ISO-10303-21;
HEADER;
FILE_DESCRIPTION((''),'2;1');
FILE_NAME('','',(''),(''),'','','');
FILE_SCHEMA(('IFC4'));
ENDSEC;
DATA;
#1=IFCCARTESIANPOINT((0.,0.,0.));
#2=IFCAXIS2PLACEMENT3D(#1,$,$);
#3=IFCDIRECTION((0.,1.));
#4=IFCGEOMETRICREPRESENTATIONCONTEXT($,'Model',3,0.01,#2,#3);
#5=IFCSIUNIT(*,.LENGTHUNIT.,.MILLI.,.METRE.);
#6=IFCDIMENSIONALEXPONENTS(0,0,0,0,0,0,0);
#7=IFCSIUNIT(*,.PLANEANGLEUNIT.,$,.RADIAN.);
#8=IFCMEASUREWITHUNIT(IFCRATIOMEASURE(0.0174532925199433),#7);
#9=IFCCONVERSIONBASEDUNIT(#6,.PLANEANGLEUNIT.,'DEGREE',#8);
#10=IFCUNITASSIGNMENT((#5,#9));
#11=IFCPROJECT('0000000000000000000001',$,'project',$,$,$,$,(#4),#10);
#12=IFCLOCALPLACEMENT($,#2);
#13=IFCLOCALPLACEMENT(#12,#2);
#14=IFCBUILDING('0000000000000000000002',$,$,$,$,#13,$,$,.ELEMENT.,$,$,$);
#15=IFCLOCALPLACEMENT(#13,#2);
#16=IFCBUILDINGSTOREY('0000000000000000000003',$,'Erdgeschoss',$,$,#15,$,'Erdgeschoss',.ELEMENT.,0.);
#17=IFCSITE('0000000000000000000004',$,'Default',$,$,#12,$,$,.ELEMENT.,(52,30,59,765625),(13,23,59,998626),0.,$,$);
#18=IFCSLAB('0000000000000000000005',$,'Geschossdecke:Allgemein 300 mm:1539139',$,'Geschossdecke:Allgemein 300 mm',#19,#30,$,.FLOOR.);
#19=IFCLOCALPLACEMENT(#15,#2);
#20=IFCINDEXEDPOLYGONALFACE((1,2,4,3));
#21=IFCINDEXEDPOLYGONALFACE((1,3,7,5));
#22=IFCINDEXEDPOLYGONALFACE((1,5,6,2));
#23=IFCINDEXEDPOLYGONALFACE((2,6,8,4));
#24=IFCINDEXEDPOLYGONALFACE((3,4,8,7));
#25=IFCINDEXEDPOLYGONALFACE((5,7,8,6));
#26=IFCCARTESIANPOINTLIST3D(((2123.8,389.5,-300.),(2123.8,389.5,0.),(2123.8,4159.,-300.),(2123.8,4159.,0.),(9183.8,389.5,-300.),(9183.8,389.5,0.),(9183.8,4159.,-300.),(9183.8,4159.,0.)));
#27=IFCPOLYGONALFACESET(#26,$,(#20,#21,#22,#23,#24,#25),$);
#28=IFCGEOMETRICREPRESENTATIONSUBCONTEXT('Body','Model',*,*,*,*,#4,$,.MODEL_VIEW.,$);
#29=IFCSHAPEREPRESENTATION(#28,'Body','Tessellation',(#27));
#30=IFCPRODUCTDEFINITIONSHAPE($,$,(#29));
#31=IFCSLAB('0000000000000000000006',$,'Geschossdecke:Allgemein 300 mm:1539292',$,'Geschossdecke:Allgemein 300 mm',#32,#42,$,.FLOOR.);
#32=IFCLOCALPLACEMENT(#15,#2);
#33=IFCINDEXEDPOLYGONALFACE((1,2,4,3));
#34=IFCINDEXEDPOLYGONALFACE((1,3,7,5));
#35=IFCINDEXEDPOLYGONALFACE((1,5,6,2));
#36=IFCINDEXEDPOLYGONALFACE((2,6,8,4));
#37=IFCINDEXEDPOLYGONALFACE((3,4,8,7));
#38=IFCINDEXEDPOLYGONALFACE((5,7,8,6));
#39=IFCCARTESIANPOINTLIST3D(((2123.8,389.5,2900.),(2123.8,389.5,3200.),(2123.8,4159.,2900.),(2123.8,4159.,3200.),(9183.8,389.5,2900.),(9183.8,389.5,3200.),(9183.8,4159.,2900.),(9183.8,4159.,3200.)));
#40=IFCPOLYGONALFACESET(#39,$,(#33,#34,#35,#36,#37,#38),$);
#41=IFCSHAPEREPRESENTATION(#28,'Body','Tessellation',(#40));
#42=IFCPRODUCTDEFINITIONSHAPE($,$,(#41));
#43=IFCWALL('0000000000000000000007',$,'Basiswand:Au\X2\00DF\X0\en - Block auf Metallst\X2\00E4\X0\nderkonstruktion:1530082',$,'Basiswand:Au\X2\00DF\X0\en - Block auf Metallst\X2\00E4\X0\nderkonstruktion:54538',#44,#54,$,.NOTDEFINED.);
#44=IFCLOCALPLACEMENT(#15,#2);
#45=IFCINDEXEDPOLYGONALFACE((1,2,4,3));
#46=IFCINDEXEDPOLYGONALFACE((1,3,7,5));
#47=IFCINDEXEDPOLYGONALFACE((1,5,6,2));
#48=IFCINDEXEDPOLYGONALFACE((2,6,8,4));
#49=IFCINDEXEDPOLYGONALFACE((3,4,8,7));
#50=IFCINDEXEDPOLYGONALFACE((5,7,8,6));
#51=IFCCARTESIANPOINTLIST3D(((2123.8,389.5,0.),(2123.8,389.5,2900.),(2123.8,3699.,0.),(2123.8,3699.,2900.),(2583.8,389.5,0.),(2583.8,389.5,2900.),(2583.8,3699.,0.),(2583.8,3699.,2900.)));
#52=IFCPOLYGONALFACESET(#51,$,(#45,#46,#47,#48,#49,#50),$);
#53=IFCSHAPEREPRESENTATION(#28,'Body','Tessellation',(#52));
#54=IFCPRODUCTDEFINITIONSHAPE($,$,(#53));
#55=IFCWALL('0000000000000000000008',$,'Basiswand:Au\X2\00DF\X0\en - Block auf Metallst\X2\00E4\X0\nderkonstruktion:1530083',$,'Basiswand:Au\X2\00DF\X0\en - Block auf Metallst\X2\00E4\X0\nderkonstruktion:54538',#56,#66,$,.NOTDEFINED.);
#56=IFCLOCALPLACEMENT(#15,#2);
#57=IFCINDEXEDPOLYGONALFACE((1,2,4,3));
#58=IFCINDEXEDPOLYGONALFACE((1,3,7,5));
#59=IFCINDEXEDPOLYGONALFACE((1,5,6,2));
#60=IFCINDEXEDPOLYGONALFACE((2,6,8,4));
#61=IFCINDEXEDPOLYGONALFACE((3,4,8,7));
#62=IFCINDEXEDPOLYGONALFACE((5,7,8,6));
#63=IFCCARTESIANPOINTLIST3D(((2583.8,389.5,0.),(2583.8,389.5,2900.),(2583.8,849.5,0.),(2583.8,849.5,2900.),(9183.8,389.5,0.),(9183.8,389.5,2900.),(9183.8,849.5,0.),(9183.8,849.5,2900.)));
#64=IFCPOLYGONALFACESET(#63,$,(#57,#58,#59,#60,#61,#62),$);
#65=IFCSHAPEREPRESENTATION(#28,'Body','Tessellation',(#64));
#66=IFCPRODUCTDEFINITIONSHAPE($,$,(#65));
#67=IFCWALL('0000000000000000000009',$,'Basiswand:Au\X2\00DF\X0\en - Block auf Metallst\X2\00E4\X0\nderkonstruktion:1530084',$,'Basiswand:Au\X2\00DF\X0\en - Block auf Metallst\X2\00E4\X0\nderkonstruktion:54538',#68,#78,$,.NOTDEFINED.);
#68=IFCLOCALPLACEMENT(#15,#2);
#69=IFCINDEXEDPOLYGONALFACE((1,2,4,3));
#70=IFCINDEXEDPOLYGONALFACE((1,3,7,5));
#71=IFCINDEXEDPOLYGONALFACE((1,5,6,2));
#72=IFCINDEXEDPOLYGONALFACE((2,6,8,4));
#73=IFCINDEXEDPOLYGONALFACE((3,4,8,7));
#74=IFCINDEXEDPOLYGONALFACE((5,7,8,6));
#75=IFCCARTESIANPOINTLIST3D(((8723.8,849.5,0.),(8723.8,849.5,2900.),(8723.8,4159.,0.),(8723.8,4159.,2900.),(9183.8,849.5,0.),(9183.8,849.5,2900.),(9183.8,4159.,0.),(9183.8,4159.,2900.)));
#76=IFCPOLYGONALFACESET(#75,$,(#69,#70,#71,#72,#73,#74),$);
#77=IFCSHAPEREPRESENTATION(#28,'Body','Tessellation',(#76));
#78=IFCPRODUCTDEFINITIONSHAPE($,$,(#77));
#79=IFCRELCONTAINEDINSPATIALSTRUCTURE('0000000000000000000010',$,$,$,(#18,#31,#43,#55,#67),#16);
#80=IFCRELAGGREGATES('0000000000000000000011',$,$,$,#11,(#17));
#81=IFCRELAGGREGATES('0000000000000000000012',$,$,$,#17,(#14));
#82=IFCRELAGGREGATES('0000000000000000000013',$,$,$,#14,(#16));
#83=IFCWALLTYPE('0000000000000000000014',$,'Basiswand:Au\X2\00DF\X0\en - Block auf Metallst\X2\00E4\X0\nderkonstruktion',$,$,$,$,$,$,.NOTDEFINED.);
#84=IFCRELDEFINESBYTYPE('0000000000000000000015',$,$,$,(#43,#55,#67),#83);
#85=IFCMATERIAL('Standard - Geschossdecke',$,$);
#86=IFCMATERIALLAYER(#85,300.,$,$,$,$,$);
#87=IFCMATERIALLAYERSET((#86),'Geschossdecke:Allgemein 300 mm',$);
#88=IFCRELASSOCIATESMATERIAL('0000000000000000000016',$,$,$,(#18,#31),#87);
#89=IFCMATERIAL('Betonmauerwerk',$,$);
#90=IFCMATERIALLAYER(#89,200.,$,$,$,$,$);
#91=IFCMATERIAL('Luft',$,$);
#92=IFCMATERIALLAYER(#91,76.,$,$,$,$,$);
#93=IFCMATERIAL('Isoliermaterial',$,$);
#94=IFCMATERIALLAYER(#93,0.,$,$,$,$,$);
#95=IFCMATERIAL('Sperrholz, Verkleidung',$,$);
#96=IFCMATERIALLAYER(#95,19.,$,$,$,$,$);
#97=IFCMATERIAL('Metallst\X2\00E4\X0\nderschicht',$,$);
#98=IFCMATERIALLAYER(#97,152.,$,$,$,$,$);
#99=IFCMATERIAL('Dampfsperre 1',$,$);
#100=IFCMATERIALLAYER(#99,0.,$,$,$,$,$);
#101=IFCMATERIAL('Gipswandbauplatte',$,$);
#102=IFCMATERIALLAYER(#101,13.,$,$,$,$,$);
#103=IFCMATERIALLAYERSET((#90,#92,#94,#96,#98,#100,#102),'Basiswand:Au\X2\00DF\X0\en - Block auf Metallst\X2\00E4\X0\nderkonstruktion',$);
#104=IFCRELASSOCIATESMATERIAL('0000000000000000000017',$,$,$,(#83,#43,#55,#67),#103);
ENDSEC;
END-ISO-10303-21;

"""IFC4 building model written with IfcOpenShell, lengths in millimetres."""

from ifc_helpers import new_model, entity, si_unit, converted_unit, direction, frame, frame_2d, origin, origin_2d_with_axis, place, context, subcontext, project, spatial, polyline, rectangle, extrude, clip, bounded_halfspace, material, layer, layer_set, layer_usage, type_object, element, save


model = new_model("IFC4")

# Units and contexts
model_context = context("Model", 3, precision=0.01, world=origin(), true_north=direction((0.0, 1.0)))
body_context = subcontext(model_context, "Body", "Model", "MODEL_VIEW")
ifc_project = project(units=[si_unit("LENGTHUNIT", "METRE", prefix="MILLI"), converted_unit("PLANEANGLEUNIT", "DEGREE", entity("IfcRatioMeasure", 0.0174532925199433), si_unit("PLANEANGLEUNIT", "RADIAN"), dimensions=[0, 0, 0, 0, 0, 0, 0])], contexts=[model_context])

# Site, building, storey
site_placement = place(None, origin())
site = spatial("IfcSite", under=ifc_project, at=site_placement, Name="Default", CompositionType="ELEMENT", RefLatitude=(52, 30, 59, 765625), RefLongitude=(13, 23, 59, 998626), RefElevation=0.0)
building_placement = place(site_placement, origin())
building = spatial("IfcBuilding", under=site, at=building_placement, CompositionType="ELEMENT")
storey_placement = place(building_placement, origin())
storey = spatial("IfcBuildingStorey", under=building, at=storey_placement, Name="Erdgeschoss", LongName="Erdgeschoss", CompositionType="ELEMENT", Elevation=0.0)

# Slabs
ifc_material_1 = material(Name="Standard - Geschossdecke")
ifc_layer_1 = layer(ifc_material_1, 300.0)
ifc_layer_set_1 = layer_set([ifc_layer_1], Name="Geschossdecke:Allgemein 300 mm")
ifc_layer_usage_1 = layer_usage(ifc_layer_set_1, "AXIS3", "POSITIVE", 0.0)
slab_1_placement = place(storey_placement, origin())
element("IfcSlab", 1, at=slab_1_placement, inside=storey, material=ifc_layer_usage_1, Name="Geschossdecke:Allgemein 300 mm:1539139", ObjectType="Geschossdecke:Allgemein 300 mm", PredefinedType="FLOOR", context=body_context, shape_type="SweptSolid", body=[
    extrude(rectangle(XDim=3769.5, YDim=7060.0, at=origin_2d_with_axis()), frame((5653.8, 2274.3, 0.0), z_axis=(0.0, 0.0, -1.0), x_axis=(0.0, 1.0, 0.0)), (0.0, 0.0, 1.0), 300.0),
])
ifc_layer_usage_2 = layer_usage(ifc_layer_set_1, "AXIS3", "POSITIVE", 0.0)
slab_2_placement = place(storey_placement, origin())
element("IfcSlab", 2, at=slab_2_placement, inside=storey, material=ifc_layer_usage_2, Name="Geschossdecke:Allgemein 300 mm:1539292", ObjectType="Geschossdecke:Allgemein 300 mm", PredefinedType="FLOOR", context=body_context, shape_type="SweptSolid", body=[
    extrude(rectangle(XDim=3769.5, YDim=7060.0, at=origin_2d_with_axis()), frame((5653.8, 2274.3, 3200.0), z_axis=(0.0, 0.0, -1.0), x_axis=(0.0, 1.0, 0.0)), (0.0, 0.0, 1.0), 300.0),
])

# Walls
ifc_material_2 = material(Name="Betonmauerwerk")
ifc_layer_2 = layer(ifc_material_2, 200.0)
ifc_material_3 = material(Name="Luft")
ifc_layer_3 = layer(ifc_material_3, 76.0)
ifc_material_4 = material(Name="Isoliermaterial")
ifc_layer_4 = layer(ifc_material_4, 0.0)
ifc_material_5 = material(Name="Sperrholz, Verkleidung")
ifc_layer_5 = layer(ifc_material_5, 19.0)
ifc_material_6 = material(Name="Metallständerschicht")
ifc_layer_6 = layer(ifc_material_6, 152.0)
ifc_material_7 = material(Name="Dampfsperre 1")
ifc_layer_7 = layer(ifc_material_7, 0.0)
ifc_material_8 = material(Name="Gipswandbauplatte")
ifc_layer_8 = layer(ifc_material_8, 13.0)
ifc_layer_set_2 = layer_set([ifc_layer_2, ifc_layer_3, ifc_layer_4, ifc_layer_5, ifc_layer_6, ifc_layer_7, ifc_layer_8], Name="Basiswand:Außen - Block auf Metallständerkonstruktion")
ifc_layer_usage_3 = layer_usage(ifc_layer_set_2, "AXIS2", "NEGATIVE", 230.0)
wall_type = type_object("IfcWallType", Name="Basiswand:Außen - Block auf Metallständerkonstruktion", PredefinedType="NOTDEFINED", material=ifc_layer_set_2)
wall_1_placement = place(storey_placement, frame((2353.8, 389.5, 0.0), z_axis=(0.0, 0.0, 1.0), x_axis=(0.0, 1.0, 0.0)))
element("IfcWall", 3, at=wall_1_placement, inside=storey, type_object=wall_type, material=ifc_layer_usage_3, Name="Basiswand:Außen - Block auf Metallständerkonstruktion:1530082", ObjectType="Basiswand:Außen - Block auf Metallständerkonstruktion:54538", PredefinedType="NOTDEFINED", context=body_context, shape_type="Clipping", body=[
    clip(extrude(rectangle(XDim=3309.5, YDim=460.0, at=frame_2d((1654.8, 0.0), x_axis=(-1.0, 0.0))), origin(), (0.0, 0.0, 1.0), 2900.0), bounded_halfspace(frame((0.0, -230.0, 2900.0), z_axis=(0.0, 0.0, -1.0), x_axis=(-1.0, 0.0, 0.0)), True, frame((0.0, -230.0, 2900.0)), polyline([(0.0, 0.0), (460.0, 0.0), (3184.5, 0.0), (3309.5, 0.0), (3309.5, 460.0), (0.0, 460.0), (0.0, 0.0)]))),
])
ifc_layer_usage_4 = layer_usage(ifc_layer_set_2, "AXIS2", "NEGATIVE", 230.0)
wall_2_placement = place(storey_placement, frame((9183.8, 619.5, 0.0), z_axis=(0.0, 0.0, 1.0), x_axis=(-1.0, 0.0, 0.0)))
element("IfcWall", 4, at=wall_2_placement, inside=storey, type_object=wall_type, material=ifc_layer_usage_4, Name="Basiswand:Außen - Block auf Metallständerkonstruktion:1530083", ObjectType="Basiswand:Außen - Block auf Metallständerkonstruktion:54538", PredefinedType="NOTDEFINED", context=body_context, shape_type="Clipping", body=[
    clip(extrude(rectangle(XDim=6600.0, YDim=460.0, at=frame_2d((3300.0, 0.0), x_axis=(-1.0, 0.0))), origin(), (0.0, 0.0, 1.0), 2900.0), bounded_halfspace(frame((0.0, -230.0, 2900.0), z_axis=(0.0, 0.0, -1.0), x_axis=(0.0, 1.0, 0.0)), True, frame((0.0, -230.0, 2900.0)), polyline([(0.0, 0.0), (460.0, 0.0), (6600.0, 0.0), (6600.0, 460.0), (0.0, 460.0), (0.0, 0.0)]))),
])
ifc_layer_usage_5 = layer_usage(ifc_layer_set_2, "AXIS2", "NEGATIVE", 230.0)
wall_3_placement = place(storey_placement, frame((8953.8, 4159.0, 0.0), z_axis=(0.0, 0.0, 1.0), x_axis=(0.0, -1.0, 0.0)))
element("IfcWall", 5, at=wall_3_placement, inside=storey, type_object=wall_type, material=ifc_layer_usage_5, Name="Basiswand:Außen - Block auf Metallständerkonstruktion:1530084", ObjectType="Basiswand:Außen - Block auf Metallständerkonstruktion:54538", PredefinedType="NOTDEFINED", context=body_context, shape_type="Clipping", body=[
    clip(extrude(rectangle(XDim=3309.5, YDim=460.0, at=frame_2d((1654.8, 0.0), x_axis=(-1.0, 0.0))), origin(), (0.0, 0.0, 1.0), 2900.0), bounded_halfspace(frame((0.0, -230.0, 2900.0), z_axis=(0.0, 0.0, -1.0), x_axis=(1.0, 0.0, 0.0)), True, frame((0.0, -230.0, 2900.0)), polyline([(0.0, 0.0), (460.0, 0.0), (585.0, 0.0), (3309.5, 0.0), (3309.5, 460.0), (0.0, 460.0), (0.0, 0.0)]))),
])

save(model, "model.ifc")
